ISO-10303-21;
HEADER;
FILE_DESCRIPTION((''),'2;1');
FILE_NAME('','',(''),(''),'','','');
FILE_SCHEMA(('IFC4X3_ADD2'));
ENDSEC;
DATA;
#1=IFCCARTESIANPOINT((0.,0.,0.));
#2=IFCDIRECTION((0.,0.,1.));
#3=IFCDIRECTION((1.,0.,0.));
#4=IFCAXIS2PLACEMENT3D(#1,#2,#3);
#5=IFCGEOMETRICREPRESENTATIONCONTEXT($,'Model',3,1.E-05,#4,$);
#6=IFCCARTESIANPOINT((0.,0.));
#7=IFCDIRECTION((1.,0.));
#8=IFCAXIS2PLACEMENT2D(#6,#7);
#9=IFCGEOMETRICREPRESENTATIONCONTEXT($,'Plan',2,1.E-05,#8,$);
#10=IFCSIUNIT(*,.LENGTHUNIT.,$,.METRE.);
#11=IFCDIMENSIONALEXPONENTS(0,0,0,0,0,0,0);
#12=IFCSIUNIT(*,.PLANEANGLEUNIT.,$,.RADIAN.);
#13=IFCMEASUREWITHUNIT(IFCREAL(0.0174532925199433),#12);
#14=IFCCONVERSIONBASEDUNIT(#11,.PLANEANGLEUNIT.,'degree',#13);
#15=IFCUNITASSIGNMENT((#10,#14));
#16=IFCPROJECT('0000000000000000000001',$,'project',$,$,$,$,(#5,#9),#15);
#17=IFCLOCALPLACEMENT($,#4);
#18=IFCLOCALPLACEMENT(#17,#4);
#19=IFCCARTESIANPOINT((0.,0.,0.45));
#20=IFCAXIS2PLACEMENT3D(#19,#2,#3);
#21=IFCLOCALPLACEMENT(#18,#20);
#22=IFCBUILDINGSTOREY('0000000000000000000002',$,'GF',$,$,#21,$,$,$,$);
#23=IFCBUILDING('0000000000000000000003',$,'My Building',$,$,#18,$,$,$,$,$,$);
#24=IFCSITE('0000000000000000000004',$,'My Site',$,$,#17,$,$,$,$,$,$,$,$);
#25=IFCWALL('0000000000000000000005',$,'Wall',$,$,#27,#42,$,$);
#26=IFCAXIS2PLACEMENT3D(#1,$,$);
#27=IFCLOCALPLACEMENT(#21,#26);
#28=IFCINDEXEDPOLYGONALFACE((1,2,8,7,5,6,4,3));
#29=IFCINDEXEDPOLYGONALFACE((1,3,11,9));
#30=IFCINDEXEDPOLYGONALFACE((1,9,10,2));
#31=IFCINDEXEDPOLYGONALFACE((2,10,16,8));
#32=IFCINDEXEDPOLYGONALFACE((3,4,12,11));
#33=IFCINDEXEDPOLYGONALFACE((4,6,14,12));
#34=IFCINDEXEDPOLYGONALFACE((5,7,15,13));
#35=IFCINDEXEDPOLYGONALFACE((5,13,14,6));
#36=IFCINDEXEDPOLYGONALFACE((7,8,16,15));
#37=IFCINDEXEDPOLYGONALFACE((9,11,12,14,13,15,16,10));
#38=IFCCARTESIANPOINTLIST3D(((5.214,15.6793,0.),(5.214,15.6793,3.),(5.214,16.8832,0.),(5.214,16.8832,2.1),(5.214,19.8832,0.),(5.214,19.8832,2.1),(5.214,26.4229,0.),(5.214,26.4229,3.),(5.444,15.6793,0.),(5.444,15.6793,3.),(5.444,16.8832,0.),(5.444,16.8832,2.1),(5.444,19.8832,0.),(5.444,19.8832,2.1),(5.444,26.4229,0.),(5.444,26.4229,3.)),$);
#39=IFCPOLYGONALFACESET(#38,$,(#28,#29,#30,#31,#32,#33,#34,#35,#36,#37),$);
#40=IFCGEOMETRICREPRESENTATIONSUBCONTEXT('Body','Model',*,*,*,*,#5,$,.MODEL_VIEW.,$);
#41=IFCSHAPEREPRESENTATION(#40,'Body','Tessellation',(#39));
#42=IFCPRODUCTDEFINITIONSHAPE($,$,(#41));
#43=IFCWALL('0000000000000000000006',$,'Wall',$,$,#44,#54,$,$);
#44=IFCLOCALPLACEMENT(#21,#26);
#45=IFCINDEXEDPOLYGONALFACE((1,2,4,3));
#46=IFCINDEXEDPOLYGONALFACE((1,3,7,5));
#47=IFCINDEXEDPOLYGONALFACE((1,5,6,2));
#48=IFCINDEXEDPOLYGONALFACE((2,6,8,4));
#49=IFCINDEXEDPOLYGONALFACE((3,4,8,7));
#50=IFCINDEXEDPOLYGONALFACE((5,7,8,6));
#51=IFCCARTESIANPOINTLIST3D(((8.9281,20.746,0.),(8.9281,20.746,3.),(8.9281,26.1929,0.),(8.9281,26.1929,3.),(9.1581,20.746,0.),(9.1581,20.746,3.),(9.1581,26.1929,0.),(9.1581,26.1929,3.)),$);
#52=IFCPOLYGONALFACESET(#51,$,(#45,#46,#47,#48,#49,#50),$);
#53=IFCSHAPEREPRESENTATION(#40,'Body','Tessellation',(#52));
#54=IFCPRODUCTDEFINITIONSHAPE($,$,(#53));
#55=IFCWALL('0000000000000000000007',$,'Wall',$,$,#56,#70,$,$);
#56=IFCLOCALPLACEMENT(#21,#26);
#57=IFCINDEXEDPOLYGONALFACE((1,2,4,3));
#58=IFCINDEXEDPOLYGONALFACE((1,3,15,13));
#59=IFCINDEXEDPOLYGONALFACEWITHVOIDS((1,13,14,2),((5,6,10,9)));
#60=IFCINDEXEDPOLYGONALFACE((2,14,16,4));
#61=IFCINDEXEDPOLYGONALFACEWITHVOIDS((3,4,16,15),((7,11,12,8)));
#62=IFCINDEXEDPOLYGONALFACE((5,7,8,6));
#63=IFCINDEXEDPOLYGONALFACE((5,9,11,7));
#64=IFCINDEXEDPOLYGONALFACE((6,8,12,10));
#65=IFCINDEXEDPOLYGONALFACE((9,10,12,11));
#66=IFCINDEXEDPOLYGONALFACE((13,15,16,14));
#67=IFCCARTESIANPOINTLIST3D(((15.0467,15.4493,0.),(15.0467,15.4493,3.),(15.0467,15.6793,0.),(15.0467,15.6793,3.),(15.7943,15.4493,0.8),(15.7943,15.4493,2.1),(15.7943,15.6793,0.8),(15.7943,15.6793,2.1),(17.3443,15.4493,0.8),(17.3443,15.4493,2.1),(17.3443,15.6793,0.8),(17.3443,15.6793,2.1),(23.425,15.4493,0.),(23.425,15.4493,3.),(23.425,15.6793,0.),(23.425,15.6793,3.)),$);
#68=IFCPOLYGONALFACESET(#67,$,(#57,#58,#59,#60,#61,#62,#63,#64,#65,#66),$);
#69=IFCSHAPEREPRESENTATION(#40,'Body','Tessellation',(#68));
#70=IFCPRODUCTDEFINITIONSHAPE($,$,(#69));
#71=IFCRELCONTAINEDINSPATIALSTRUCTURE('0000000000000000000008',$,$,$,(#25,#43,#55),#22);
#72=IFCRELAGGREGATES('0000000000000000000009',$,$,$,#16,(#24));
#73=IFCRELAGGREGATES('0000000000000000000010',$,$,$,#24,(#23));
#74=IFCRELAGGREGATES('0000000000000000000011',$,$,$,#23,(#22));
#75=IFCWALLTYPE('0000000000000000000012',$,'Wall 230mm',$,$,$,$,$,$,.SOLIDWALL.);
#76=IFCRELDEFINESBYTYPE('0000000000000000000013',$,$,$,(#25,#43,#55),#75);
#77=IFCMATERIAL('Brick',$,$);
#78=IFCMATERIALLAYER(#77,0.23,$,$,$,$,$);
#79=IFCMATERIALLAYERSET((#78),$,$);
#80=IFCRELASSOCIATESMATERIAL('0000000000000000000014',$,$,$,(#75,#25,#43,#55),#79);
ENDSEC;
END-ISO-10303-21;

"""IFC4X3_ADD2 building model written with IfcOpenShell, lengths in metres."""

from ifc_helpers import new_model, entity, si_unit, converted_unit, frame, origin_with_axes, origin_2d_with_axis, place, context, subcontext, project, spatial, line, indexed_curve, outline, extrude, source, transform, mapped, material, layer, layer_set, layer_usage, type_object, element, save


model = new_model("IFC4X3_ADD2")

# Units and contexts
model_context = context("Model", 3, precision=1e-05, world=origin_with_axes())
plan_context = context("Plan", 2, precision=1e-05, world=origin_2d_with_axis())
body_context_1 = subcontext(model_context, "Body", "Model", "MODEL_VIEW")
ifc_project = project(units=[si_unit("LENGTHUNIT", "METRE"), converted_unit("PLANEANGLEUNIT", "degree", entity("IfcReal", 0.0174532925199433), si_unit("PLANEANGLEUNIT", "RADIAN"), dimensions=[0, 0, 0, 0, 0, 0, 0])], contexts=[model_context, plan_context])

# Site, building, storey
site_placement = place(None, origin_with_axes())
site = spatial("IfcSite", under=ifc_project, at=site_placement, Name="My Site")
building_placement = place(site_placement, origin_with_axes())
building = spatial("IfcBuilding", under=site, at=building_placement, Name="My Building")
storey_placement = place(building_placement, frame((0.0, 0.0, 0.45), z_axis=(0.0, 0.0, 1.0), x_axis=(1.0, 0.0, 0.0)))
storey = spatial("IfcBuildingStorey", under=building, at=storey_placement, Name="GF")

# Wall, opening
ifc_material = material(Name="Brick")
ifc_layer_1 = layer(ifc_material, 0.23)
ifc_layer_set_1 = layer_set([ifc_layer_1])
ifc_layer_usage_1 = layer_usage(ifc_layer_set_1, "AXIS2", "POSITIVE", 0.0)
wall_type_1 = type_object("IfcWallType", Name="Wall 230mm", PredefinedType="SOLIDWALL", material=ifc_layer_set_1)
wall_1_placement = place(storey_placement, frame((5.444, 15.6793, 0.0), z_axis=(0.0, 0.0, 1.0), x_axis=(0.0, 1.0, 0.0)))
wall_1 = element("IfcWall", 1, at=wall_1_placement, inside=storey, type_object=wall_type_1, material=ifc_layer_usage_1, Name="Wall", context=body_context_1, shape_type="SweptSolid", body=[
    extrude(outline(indexed_curve([(0.0, 0.0), (0.0, 0.23), (10.7436, 0.23), (10.7436, 0.0), (0.0, 0.0)], self_intersect=False)), origin_with_axes(), (0.0, 0.0, 1.0), 3.0),
])
shared_shape_1 = source(origin_with_axes(), body_context_1, "Body", "SweptSolid", [
    extrude(outline(indexed_curve([(0.0, 0.0), (3.0, 0.0), (3.0, 2.1), (0.0, 2.1)], segments=[line(1, 2, 3, 4, 1)])), frame((0.0, -0.6, 0.0), z_axis=(0.0, -1.0, 0.0), x_axis=(1.0, 0.0, 0.0)), (0.0, 0.0, -1.0), 1.2),
])
opening_1_placement = place(wall_1_placement, frame((1.2039, 0.0, 0.0), z_axis=(0.0, 0.0, 1.0), x_axis=(1.0, 0.0, 0.0)))
element("IfcOpeningElement", 2, at=opening_1_placement, cuts=wall_1, PredefinedType="OPENING", context=body_context_1, shape_type="MappedRepresentation", body=[
    mapped(shared_shape_1, transform((0.0, 0.0, 0.0), x_axis=(1.0, 0.0, 0.0), y_axis=(0.0, 1.0, 0.0), z_axis=(0.0, 0.0, 1.0), scale=1.0)),
])

# Wall
ifc_layer_usage_2 = layer_usage(ifc_layer_set_1, "AXIS2", "POSITIVE", 0.0)
wall_2_placement = place(storey_placement, frame((9.1581, 20.746, 0.0), z_axis=(0.0, 0.0, 1.0), x_axis=(0.0, 1.0, 0.0)))
element("IfcWall", 3, at=wall_2_placement, inside=storey, type_object=wall_type_1, material=ifc_layer_usage_2, Name="Wall", context=body_context_1, shape_type="SweptSolid", body=[
    extrude(outline(indexed_curve([(0.0, 0.0), (0.0, 0.23), (5.4469, 0.23), (5.4469, 0.0), (0.0, 0.0)], self_intersect=False)), origin_with_axes(), (0.0, 0.0, 1.0), 3.0),
])

# Wall, opening
ifc_layer_usage_3 = layer_usage(ifc_layer_set_1, "AXIS2", "POSITIVE", 0.0)
wall_3_placement = place(storey_placement, frame((15.0467, 15.4493, 0.0), z_axis=(0.0, 0.0, 1.0), x_axis=(1.0, 0.0, 0.0)))
wall_3 = element("IfcWall", 4, at=wall_3_placement, inside=storey, type_object=wall_type_1, material=ifc_layer_usage_3, Name="Wall", context=body_context_1, shape_type="SweptSolid", body=[
    extrude(outline(indexed_curve([(0.0, 0.0), (0.0, 0.23), (8.3783, 0.23), (8.3783, 0.0), (0.0, 0.0)], self_intersect=False)), origin_with_axes(), (0.0, 0.0, 1.0), 3.0),
])
shared_shape_2 = source(origin_with_axes(), body_context_1, "Body", "SweptSolid", [
    extrude(outline(indexed_curve([(0.0, 0.0), (1.55, 0.0), (1.55, 1.3), (0.0, 1.3)], segments=[line(1, 2, 3, 4, 1)])), frame((-0.775, -0.6, 0.0), z_axis=(0.0, -1.0, 0.0), x_axis=(1.0, 0.0, 0.0)), (0.0, 0.0, -1.0), 1.2),
])
opening_2_placement = place(wall_3_placement, frame((1.5226, 0.015, 0.8), z_axis=(0.0, 0.0, 1.0), x_axis=(1.0, 0.0, 0.0)))
element("IfcOpeningElement", 5, at=opening_2_placement, cuts=wall_3, PredefinedType="OPENING", context=body_context_1, shape_type="MappedRepresentation", body=[
    mapped(shared_shape_2, transform((0.0, 0.0, 0.0), x_axis=(1.0, 0.0, 0.0), y_axis=(0.0, 1.0, 0.0), z_axis=(0.0, 0.0, 1.0), scale=1.0)),
])

save(model, "model.ifc")
